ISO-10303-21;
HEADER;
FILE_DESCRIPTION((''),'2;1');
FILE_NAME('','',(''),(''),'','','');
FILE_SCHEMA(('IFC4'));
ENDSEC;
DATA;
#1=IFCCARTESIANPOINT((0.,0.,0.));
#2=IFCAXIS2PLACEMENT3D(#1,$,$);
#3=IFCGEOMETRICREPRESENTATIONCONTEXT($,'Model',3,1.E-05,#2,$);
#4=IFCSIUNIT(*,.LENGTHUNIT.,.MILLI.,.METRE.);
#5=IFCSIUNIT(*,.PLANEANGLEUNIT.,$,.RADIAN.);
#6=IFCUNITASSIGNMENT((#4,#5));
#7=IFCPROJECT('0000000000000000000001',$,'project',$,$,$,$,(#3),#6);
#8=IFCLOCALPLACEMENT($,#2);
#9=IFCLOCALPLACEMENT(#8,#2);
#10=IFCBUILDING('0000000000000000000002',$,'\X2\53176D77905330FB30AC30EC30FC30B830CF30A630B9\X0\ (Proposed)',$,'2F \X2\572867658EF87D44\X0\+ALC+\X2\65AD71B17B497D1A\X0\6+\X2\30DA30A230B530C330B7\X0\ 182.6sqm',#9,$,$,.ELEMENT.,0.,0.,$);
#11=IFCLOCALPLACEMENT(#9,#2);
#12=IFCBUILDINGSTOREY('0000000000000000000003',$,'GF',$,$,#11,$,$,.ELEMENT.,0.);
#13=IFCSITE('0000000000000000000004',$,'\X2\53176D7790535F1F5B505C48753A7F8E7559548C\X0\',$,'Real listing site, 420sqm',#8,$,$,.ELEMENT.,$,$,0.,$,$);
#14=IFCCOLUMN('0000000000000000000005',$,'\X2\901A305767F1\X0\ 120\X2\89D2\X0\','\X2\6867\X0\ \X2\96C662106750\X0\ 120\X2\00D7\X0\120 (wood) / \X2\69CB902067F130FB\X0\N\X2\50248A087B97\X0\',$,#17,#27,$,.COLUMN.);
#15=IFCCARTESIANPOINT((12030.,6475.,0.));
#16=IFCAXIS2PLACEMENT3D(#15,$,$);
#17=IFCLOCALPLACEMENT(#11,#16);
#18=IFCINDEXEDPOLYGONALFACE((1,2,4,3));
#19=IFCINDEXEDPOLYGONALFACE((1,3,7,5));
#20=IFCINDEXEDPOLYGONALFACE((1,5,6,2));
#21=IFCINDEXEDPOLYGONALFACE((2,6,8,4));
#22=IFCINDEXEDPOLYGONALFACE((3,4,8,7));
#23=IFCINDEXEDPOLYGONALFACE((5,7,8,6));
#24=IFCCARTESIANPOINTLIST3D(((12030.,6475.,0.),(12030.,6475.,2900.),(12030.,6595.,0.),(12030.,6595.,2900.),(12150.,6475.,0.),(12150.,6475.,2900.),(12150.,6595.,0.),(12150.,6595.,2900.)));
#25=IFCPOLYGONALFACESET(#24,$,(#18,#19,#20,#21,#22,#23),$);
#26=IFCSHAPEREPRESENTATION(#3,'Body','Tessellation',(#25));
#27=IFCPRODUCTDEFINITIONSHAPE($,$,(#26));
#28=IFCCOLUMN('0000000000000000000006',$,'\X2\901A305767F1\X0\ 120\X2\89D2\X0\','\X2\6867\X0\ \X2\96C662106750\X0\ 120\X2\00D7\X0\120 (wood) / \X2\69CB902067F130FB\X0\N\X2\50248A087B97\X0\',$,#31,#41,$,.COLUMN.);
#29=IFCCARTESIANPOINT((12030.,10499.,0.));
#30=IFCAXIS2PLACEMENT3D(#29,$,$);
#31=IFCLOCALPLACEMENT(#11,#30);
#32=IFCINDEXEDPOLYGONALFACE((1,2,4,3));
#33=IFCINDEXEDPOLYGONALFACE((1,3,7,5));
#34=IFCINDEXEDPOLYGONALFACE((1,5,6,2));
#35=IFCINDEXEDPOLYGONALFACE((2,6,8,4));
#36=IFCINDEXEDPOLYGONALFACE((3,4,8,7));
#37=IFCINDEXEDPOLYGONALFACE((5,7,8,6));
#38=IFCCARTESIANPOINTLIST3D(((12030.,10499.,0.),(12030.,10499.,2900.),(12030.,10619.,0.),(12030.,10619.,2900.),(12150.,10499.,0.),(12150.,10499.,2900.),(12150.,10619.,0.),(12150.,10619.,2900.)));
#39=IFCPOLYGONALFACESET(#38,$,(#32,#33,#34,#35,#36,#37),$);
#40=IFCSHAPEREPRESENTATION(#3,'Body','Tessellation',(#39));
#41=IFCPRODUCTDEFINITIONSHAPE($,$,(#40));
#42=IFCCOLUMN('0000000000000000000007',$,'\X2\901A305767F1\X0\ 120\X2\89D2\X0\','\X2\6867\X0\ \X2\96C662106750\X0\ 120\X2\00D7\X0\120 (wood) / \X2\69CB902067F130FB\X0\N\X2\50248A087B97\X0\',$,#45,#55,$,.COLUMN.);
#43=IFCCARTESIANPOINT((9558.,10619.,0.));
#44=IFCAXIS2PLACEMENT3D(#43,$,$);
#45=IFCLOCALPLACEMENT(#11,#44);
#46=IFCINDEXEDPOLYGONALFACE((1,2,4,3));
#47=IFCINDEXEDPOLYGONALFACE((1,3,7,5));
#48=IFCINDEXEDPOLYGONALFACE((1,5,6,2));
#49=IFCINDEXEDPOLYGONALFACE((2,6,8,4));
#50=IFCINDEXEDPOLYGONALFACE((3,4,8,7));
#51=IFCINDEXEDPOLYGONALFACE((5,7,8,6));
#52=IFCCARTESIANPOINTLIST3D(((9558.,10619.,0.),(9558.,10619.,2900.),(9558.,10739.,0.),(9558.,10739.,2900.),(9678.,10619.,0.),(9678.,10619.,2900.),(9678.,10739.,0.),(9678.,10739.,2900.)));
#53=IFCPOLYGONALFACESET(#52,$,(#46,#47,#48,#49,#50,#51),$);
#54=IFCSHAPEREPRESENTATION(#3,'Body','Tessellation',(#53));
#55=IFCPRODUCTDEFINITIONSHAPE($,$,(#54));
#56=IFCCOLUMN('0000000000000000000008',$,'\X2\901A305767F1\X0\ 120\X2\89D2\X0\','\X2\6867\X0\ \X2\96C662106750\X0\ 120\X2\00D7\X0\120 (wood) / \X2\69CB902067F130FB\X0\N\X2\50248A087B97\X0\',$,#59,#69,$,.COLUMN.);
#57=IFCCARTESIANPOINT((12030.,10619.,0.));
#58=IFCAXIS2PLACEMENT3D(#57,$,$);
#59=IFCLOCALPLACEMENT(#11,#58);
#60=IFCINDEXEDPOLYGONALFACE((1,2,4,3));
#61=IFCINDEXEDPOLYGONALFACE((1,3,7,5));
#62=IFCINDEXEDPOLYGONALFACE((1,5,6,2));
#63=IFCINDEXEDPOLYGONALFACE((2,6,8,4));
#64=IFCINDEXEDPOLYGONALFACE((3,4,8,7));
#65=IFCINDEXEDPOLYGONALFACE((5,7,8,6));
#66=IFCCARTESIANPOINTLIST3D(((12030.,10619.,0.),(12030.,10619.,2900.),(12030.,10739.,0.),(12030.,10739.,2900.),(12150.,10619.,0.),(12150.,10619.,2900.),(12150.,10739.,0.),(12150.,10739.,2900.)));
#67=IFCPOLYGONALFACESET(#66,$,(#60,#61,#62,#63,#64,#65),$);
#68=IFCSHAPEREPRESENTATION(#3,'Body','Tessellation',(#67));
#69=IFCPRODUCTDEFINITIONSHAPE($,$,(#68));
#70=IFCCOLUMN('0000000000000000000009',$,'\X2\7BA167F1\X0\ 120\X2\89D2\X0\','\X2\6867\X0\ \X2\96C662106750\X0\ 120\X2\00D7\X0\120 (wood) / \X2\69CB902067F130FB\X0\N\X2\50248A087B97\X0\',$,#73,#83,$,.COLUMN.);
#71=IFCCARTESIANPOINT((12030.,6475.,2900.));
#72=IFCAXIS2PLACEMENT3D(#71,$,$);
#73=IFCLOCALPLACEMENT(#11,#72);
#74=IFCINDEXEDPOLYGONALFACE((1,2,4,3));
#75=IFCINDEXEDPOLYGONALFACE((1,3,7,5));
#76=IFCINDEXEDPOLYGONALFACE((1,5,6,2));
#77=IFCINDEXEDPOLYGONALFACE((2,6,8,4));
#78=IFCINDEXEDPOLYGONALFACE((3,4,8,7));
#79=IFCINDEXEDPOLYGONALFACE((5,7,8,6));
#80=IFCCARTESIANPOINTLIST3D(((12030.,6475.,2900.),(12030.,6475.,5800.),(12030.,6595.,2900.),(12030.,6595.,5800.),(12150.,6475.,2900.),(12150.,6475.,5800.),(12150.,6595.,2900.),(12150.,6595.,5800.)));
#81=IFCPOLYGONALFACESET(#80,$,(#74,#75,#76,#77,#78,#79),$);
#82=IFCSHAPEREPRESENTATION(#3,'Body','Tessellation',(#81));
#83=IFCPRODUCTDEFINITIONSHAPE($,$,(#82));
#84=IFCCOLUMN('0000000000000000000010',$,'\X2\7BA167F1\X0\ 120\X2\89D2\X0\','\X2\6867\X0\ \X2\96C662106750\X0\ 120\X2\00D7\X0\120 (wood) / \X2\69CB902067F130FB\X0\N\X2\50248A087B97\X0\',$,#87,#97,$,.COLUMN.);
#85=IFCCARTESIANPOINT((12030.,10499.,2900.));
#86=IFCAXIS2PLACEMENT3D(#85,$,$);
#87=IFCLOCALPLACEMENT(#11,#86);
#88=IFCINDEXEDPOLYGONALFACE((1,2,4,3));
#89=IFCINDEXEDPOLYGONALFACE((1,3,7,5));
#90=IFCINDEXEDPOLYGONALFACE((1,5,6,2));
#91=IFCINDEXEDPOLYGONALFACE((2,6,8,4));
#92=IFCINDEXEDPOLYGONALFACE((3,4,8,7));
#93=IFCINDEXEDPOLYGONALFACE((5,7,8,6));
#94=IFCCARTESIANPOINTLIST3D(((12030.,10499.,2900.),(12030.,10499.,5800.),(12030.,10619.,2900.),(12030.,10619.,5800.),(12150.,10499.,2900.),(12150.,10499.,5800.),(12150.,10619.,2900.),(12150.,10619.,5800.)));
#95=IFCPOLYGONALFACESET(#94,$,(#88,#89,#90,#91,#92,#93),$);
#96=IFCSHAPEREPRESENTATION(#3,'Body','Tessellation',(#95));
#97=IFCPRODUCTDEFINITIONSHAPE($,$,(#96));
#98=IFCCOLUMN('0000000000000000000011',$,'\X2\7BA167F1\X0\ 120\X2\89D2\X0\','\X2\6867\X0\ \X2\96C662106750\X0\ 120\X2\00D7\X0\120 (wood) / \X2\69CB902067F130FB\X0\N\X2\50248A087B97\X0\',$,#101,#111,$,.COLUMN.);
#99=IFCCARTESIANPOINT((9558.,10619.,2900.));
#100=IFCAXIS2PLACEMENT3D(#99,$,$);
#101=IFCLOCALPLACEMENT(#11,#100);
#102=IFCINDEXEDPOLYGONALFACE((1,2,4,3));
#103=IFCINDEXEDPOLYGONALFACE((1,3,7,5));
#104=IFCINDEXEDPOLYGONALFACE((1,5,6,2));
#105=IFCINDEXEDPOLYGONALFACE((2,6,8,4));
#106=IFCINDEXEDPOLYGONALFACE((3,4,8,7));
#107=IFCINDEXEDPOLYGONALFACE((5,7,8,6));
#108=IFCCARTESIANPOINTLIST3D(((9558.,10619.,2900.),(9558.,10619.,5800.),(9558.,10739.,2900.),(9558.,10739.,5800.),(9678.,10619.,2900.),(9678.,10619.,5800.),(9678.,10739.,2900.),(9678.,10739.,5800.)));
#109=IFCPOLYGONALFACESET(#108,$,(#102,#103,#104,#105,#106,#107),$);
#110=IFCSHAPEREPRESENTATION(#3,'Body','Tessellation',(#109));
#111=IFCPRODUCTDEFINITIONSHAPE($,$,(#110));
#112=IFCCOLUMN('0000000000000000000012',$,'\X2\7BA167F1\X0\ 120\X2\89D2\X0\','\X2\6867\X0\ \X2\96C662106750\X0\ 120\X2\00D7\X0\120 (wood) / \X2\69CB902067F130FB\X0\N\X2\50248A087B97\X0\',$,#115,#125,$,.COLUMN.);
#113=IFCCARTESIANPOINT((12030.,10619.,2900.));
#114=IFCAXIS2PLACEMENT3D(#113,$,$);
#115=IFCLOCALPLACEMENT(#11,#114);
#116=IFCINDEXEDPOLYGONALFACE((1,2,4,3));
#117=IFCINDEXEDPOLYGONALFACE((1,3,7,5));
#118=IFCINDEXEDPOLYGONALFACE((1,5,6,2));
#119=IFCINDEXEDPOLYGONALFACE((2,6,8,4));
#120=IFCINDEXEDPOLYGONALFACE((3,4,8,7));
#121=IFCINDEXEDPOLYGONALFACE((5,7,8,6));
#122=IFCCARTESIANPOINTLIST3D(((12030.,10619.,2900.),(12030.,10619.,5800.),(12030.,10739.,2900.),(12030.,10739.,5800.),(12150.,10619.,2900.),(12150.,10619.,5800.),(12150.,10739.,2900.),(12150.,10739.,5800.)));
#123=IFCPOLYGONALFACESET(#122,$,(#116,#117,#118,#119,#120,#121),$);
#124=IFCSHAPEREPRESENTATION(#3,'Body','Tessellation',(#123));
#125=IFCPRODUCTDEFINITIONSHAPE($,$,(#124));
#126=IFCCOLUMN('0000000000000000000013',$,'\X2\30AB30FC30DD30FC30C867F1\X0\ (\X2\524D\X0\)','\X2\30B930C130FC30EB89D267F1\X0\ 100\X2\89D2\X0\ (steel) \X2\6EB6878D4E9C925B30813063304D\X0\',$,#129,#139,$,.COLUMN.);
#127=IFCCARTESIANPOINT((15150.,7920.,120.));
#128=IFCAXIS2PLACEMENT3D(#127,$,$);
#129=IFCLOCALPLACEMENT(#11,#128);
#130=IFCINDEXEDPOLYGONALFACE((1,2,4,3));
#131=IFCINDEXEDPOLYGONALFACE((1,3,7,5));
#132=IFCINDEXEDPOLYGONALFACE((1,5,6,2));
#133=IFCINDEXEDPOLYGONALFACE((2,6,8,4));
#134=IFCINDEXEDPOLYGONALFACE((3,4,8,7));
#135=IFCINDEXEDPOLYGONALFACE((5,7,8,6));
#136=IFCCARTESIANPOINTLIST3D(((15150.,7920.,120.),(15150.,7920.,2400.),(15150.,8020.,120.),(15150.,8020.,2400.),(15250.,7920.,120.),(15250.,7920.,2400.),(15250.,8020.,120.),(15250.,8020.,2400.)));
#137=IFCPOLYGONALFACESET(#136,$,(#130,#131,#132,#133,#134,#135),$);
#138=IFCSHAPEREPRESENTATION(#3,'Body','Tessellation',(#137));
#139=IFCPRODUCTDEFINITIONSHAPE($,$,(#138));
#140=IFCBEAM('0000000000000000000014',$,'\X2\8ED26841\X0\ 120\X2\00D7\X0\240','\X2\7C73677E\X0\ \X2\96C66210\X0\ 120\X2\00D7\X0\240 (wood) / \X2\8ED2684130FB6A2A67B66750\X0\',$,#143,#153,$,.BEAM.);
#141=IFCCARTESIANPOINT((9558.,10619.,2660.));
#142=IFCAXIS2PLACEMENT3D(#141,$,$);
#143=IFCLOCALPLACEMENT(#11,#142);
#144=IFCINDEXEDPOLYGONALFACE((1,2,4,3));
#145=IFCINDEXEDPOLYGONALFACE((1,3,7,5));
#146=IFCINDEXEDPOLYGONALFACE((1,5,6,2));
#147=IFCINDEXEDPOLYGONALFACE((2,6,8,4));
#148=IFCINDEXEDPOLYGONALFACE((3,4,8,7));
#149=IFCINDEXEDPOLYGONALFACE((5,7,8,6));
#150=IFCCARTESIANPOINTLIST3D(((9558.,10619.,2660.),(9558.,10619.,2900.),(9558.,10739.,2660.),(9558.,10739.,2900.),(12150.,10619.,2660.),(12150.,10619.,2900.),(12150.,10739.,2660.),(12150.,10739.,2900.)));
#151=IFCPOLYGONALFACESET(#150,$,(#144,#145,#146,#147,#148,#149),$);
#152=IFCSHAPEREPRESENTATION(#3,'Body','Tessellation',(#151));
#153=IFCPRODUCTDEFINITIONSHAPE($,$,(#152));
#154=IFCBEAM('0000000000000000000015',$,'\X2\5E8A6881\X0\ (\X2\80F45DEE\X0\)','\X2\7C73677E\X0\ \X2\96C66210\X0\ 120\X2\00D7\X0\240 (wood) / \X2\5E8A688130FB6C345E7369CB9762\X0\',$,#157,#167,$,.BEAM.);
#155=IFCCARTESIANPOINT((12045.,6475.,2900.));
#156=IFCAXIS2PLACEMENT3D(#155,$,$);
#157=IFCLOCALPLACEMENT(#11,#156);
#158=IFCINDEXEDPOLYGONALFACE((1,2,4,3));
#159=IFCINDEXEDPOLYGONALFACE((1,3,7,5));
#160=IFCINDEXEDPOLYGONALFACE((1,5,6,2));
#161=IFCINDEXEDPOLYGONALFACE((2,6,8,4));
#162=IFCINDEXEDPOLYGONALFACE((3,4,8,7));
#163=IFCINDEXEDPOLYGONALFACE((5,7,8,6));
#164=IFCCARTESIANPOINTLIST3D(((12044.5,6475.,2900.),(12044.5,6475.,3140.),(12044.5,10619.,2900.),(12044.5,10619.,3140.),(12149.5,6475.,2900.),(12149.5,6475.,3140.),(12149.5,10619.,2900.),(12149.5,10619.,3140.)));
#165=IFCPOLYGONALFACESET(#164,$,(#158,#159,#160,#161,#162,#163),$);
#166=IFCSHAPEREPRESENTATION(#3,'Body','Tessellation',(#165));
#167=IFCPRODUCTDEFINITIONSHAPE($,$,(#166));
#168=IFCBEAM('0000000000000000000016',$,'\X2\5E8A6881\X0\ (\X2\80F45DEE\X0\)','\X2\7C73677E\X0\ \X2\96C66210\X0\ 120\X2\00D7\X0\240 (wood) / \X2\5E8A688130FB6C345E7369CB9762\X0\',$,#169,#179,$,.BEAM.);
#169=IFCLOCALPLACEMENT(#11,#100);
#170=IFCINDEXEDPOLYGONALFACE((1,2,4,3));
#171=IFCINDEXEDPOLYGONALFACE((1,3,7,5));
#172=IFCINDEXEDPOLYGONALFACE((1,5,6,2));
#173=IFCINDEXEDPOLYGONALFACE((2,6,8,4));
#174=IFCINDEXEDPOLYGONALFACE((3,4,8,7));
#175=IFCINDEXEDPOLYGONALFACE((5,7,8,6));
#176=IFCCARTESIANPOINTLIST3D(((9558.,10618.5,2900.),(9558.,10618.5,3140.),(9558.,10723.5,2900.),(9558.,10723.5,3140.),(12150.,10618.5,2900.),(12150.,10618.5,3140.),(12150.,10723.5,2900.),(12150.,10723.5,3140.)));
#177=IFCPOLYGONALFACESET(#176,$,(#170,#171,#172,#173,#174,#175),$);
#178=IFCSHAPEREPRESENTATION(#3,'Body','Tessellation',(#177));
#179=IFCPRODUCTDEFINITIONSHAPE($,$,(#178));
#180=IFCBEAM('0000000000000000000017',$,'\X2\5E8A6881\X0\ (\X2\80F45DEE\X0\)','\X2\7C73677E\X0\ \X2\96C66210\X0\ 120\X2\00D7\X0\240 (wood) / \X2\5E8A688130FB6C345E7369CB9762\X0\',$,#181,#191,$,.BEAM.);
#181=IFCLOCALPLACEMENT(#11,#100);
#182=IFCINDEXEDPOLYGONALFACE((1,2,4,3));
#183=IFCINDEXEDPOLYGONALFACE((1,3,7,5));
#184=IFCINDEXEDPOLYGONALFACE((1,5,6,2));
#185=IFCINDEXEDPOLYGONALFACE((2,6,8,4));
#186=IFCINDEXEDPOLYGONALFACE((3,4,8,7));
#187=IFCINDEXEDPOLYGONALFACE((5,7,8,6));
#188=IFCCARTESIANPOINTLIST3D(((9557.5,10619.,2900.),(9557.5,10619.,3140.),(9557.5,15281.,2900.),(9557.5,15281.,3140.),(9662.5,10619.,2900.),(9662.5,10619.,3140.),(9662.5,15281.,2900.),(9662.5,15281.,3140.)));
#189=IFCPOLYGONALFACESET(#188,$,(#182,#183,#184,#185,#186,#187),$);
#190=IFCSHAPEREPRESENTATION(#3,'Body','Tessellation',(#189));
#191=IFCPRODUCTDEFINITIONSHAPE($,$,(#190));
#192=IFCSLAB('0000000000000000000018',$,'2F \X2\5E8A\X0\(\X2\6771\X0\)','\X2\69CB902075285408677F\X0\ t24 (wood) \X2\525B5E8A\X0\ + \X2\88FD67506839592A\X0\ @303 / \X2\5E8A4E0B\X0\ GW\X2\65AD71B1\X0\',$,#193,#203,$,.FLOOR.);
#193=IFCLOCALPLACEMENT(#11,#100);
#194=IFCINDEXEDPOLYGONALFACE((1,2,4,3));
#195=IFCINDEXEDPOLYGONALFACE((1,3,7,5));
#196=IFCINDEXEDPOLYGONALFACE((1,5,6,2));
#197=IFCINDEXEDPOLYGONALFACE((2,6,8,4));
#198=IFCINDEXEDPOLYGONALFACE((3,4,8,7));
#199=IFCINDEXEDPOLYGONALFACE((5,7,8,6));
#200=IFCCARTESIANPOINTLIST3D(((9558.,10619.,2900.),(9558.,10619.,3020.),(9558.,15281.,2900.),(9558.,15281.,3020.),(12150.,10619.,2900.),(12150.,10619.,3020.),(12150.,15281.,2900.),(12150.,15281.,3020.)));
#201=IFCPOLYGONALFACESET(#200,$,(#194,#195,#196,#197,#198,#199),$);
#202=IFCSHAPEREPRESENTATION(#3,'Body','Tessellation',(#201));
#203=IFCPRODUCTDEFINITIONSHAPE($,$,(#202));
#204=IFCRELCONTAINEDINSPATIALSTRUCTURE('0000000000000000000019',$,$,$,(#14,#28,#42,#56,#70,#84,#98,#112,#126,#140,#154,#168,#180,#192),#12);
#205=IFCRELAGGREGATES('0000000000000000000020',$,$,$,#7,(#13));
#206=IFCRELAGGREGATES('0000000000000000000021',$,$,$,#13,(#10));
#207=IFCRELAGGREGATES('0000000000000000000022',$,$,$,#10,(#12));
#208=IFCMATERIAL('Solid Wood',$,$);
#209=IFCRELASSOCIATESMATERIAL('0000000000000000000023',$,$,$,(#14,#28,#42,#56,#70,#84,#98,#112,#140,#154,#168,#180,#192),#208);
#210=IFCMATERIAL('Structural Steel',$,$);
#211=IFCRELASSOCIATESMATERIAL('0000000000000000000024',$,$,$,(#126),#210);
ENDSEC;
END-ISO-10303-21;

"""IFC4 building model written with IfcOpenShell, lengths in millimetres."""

from ifc_helpers import new_model, si_unit, frame, frame_2d, origin, place, context, project, spatial, rectangle, extrude, material, element, save


model = new_model("IFC4")

# Units and contexts
model_context = context("Model", 3, precision=1e-05, world=origin())
ifc_project = project(units=[si_unit("LENGTHUNIT", "METRE", prefix="MILLI"), si_unit("PLANEANGLEUNIT", "RADIAN")], contexts=[model_context])

# Site, building, storey
site_placement = place(None, origin())
site = spatial("IfcSite", under=ifc_project, at=site_placement, Name="北海道弟子屈町美留和", ObjectType="Real listing site, 420sqm", CompositionType="ELEMENT", RefElevation=0.0)
building_placement = place(site_placement, origin())
building = spatial("IfcBuilding", under=site, at=building_placement, Name="北海道・ガレージハウス (Proposed)", ObjectType="2F 在来軸組+ALC+断熱等級6+ペアサッシ 182.6sqm", CompositionType="ELEMENT", ElevationOfRefHeight=0.0, ElevationOfTerrain=0.0)
storey_placement = place(building_placement, origin())
storey = spatial("IfcBuildingStorey", under=building, at=storey_placement, Name="GF", CompositionType="ELEMENT", Elevation=0.0)

# Columns
ifc_material_1 = material(Name="Solid Wood")
column_1_placement = place(storey_placement, frame((12030.0, 6475.0, 0.0)))
element("IfcColumn", 1, at=column_1_placement, inside=storey, material=ifc_material_1, Name="通し柱 120角", Description="桧 集成材 120×120 (wood) / 構造柱・N値計算", PredefinedType="COLUMN", context=model_context, shape_type="SweptSolid", body=[
    extrude(rectangle(XDim=120.0, YDim=120.0, at=frame_2d((60.0, 60.0))), frame((12030.0, 6475.0, 0.0)), (0.0, 0.0, 1.0), 2900.0),
])
column_2_placement = place(storey_placement, frame((12030.0, 10499.0, 0.0)))
element("IfcColumn", 2, at=column_2_placement, inside=storey, material=ifc_material_1, Name="通し柱 120角", Description="桧 集成材 120×120 (wood) / 構造柱・N値計算", PredefinedType="COLUMN", context=model_context, shape_type="SweptSolid", body=[
    extrude(rectangle(XDim=120.0, YDim=120.0, at=frame_2d((60.0, 60.0))), frame((12030.0, 10499.0, 0.0)), (0.0, 0.0, 1.0), 2900.0),
])
column_3_placement = place(storey_placement, frame((9558.0, 10619.0, 0.0)))
element("IfcColumn", 3, at=column_3_placement, inside=storey, material=ifc_material_1, Name="通し柱 120角", Description="桧 集成材 120×120 (wood) / 構造柱・N値計算", PredefinedType="COLUMN", context=model_context, shape_type="SweptSolid", body=[
    extrude(rectangle(XDim=120.0, YDim=120.0, at=frame_2d((60.0, 60.0))), frame((9558.0, 10619.0, 0.0)), (0.0, 0.0, 1.0), 2900.0),
])
column_4_placement = place(storey_placement, frame((12030.0, 10619.0, 0.0)))
element("IfcColumn", 4, at=column_4_placement, inside=storey, material=ifc_material_1, Name="通し柱 120角", Description="桧 集成材 120×120 (wood) / 構造柱・N値計算", PredefinedType="COLUMN", context=model_context, shape_type="SweptSolid", body=[
    extrude(rectangle(XDim=120.0, YDim=120.0, at=frame_2d((60.0, 60.0))), frame((12030.0, 10619.0, 0.0)), (0.0, 0.0, 1.0), 2900.0),
])
column_5_placement = place(storey_placement, frame((12030.0, 6475.0, 2900.0)))
element("IfcColumn", 5, at=column_5_placement, inside=storey, material=ifc_material_1, Name="管柱 120角", Description="桧 集成材 120×120 (wood) / 構造柱・N値計算", PredefinedType="COLUMN", context=model_context, shape_type="SweptSolid", body=[
    extrude(rectangle(XDim=120.0, YDim=120.0, at=frame_2d((60.0, 60.0))), frame((12030.0, 6475.0, 2900.0)), (0.0, 0.0, 1.0), 2900.0),
])
column_6_placement = place(storey_placement, frame((12030.0, 10499.0, 2900.0)))
element("IfcColumn", 6, at=column_6_placement, inside=storey, material=ifc_material_1, Name="管柱 120角", Description="桧 集成材 120×120 (wood) / 構造柱・N値計算", PredefinedType="COLUMN", context=model_context, shape_type="SweptSolid", body=[
    extrude(rectangle(XDim=120.0, YDim=120.0, at=frame_2d((60.0, 60.0))), frame((12030.0, 10499.0, 2900.0)), (0.0, 0.0, 1.0), 2900.0),
])
column_7_placement = place(storey_placement, frame((9558.0, 10619.0, 2900.0)))
element("IfcColumn", 7, at=column_7_placement, inside=storey, material=ifc_material_1, Name="管柱 120角", Description="桧 集成材 120×120 (wood) / 構造柱・N値計算", PredefinedType="COLUMN", context=model_context, shape_type="SweptSolid", body=[
    extrude(rectangle(XDim=120.0, YDim=120.0, at=frame_2d((60.0, 60.0))), frame((9558.0, 10619.0, 2900.0)), (0.0, 0.0, 1.0), 2900.0),
])
column_8_placement = place(storey_placement, frame((12030.0, 10619.0, 2900.0)))
element("IfcColumn", 8, at=column_8_placement, inside=storey, material=ifc_material_1, Name="管柱 120角", Description="桧 集成材 120×120 (wood) / 構造柱・N値計算", PredefinedType="COLUMN", context=model_context, shape_type="SweptSolid", body=[
    extrude(rectangle(XDim=120.0, YDim=120.0, at=frame_2d((60.0, 60.0))), frame((12030.0, 10619.0, 2900.0)), (0.0, 0.0, 1.0), 2900.0),
])
ifc_material_2 = material(Name="Structural Steel")
column_9_placement = place(storey_placement, frame((15150.0, 7920.0, 120.0)))
element("IfcColumn", 9, at=column_9_placement, inside=storey, material=ifc_material_2, Name="カーポート柱 (前)", Description="スチール角柱 100角 (steel) 溶融亜鉛めっき", PredefinedType="COLUMN", context=model_context, shape_type="SweptSolid", body=[
    extrude(rectangle(XDim=100.0, YDim=100.0, at=frame_2d((50.0, 50.0))), frame((15150.0, 7920.0, 120.0)), (0.0, 0.0, 1.0), 2280.0),
])

# Beams
beam_1_placement = place(storey_placement, frame((9558.0, 10619.0, 2660.0)))
element("IfcBeam", 10, at=beam_1_placement, inside=storey, material=ifc_material_1, Name="軒桁 120×240", Description="米松 集成 120×240 (wood) / 軒桁・横架材", PredefinedType="BEAM", context=model_context, shape_type="SweptSolid", body=[
    extrude(rectangle(XDim=2592.0, YDim=120.0, at=frame_2d((1296.0, 60.0))), frame((9558.0, 10619.0, 2660.0)), (0.0, 0.0, 1.0), 240.0),
])
beam_2_placement = place(storey_placement, frame((12045.0, 6475.0, 2900.0)))
element("IfcBeam", 11, at=beam_2_placement, inside=storey, material=ifc_material_1, Name="床梁 (胴差)", Description="米松 集成 120×240 (wood) / 床梁・水平構面", PredefinedType="BEAM", context=model_context, shape_type="SweptSolid", body=[
    extrude(rectangle(XDim=105.0, YDim=4144.0, at=frame_2d((52.0, 2072.0))), frame((12045.0, 6475.0, 2900.0)), (0.0, 0.0, 1.0), 240.0),
])
beam_3_placement = place(storey_placement, frame((9558.0, 10619.0, 2900.0)))
element("IfcBeam", 12, at=beam_3_placement, inside=storey, material=ifc_material_1, Name="床梁 (胴差)", Description="米松 集成 120×240 (wood) / 床梁・水平構面", PredefinedType="BEAM", context=model_context, shape_type="SweptSolid", body=[
    extrude(rectangle(XDim=2592.0, YDim=105.0, at=frame_2d((1296.0, 52.0))), frame((9558.0, 10619.0, 2900.0)), (0.0, 0.0, 1.0), 240.0),
])
beam_4_placement = place(storey_placement, frame((9558.0, 10619.0, 2900.0)))
element("IfcBeam", 13, at=beam_4_placement, inside=storey, material=ifc_material_1, Name="床梁 (胴差)", Description="米松 集成 120×240 (wood) / 床梁・水平構面", PredefinedType="BEAM", context=model_context, shape_type="SweptSolid", body=[
    extrude(rectangle(XDim=105.0, YDim=4662.0, at=frame_2d((52.0, 2331.0))), frame((9558.0, 10619.0, 2900.0)), (0.0, 0.0, 1.0), 240.0),
])

# Slab
slab_1_placement = place(storey_placement, frame((9558.0, 10619.0, 2900.0)))
element("IfcSlab", 14, at=slab_1_placement, inside=storey, material=ifc_material_1, Name="2F 床(東)", Description="構造用合板 t24 (wood) 剛床 + 製材根太 @303 / 床下 GW断熱", PredefinedType="FLOOR", context=model_context, shape_type="SweptSolid", body=[
    extrude(rectangle(XDim=2592.0, YDim=4662.0, at=frame_2d((1296.0, 2331.0))), frame((9558.0, 10619.0, 2900.0)), (0.0, 0.0, 1.0), 120.0),
])

save(model, "model.ifc")
